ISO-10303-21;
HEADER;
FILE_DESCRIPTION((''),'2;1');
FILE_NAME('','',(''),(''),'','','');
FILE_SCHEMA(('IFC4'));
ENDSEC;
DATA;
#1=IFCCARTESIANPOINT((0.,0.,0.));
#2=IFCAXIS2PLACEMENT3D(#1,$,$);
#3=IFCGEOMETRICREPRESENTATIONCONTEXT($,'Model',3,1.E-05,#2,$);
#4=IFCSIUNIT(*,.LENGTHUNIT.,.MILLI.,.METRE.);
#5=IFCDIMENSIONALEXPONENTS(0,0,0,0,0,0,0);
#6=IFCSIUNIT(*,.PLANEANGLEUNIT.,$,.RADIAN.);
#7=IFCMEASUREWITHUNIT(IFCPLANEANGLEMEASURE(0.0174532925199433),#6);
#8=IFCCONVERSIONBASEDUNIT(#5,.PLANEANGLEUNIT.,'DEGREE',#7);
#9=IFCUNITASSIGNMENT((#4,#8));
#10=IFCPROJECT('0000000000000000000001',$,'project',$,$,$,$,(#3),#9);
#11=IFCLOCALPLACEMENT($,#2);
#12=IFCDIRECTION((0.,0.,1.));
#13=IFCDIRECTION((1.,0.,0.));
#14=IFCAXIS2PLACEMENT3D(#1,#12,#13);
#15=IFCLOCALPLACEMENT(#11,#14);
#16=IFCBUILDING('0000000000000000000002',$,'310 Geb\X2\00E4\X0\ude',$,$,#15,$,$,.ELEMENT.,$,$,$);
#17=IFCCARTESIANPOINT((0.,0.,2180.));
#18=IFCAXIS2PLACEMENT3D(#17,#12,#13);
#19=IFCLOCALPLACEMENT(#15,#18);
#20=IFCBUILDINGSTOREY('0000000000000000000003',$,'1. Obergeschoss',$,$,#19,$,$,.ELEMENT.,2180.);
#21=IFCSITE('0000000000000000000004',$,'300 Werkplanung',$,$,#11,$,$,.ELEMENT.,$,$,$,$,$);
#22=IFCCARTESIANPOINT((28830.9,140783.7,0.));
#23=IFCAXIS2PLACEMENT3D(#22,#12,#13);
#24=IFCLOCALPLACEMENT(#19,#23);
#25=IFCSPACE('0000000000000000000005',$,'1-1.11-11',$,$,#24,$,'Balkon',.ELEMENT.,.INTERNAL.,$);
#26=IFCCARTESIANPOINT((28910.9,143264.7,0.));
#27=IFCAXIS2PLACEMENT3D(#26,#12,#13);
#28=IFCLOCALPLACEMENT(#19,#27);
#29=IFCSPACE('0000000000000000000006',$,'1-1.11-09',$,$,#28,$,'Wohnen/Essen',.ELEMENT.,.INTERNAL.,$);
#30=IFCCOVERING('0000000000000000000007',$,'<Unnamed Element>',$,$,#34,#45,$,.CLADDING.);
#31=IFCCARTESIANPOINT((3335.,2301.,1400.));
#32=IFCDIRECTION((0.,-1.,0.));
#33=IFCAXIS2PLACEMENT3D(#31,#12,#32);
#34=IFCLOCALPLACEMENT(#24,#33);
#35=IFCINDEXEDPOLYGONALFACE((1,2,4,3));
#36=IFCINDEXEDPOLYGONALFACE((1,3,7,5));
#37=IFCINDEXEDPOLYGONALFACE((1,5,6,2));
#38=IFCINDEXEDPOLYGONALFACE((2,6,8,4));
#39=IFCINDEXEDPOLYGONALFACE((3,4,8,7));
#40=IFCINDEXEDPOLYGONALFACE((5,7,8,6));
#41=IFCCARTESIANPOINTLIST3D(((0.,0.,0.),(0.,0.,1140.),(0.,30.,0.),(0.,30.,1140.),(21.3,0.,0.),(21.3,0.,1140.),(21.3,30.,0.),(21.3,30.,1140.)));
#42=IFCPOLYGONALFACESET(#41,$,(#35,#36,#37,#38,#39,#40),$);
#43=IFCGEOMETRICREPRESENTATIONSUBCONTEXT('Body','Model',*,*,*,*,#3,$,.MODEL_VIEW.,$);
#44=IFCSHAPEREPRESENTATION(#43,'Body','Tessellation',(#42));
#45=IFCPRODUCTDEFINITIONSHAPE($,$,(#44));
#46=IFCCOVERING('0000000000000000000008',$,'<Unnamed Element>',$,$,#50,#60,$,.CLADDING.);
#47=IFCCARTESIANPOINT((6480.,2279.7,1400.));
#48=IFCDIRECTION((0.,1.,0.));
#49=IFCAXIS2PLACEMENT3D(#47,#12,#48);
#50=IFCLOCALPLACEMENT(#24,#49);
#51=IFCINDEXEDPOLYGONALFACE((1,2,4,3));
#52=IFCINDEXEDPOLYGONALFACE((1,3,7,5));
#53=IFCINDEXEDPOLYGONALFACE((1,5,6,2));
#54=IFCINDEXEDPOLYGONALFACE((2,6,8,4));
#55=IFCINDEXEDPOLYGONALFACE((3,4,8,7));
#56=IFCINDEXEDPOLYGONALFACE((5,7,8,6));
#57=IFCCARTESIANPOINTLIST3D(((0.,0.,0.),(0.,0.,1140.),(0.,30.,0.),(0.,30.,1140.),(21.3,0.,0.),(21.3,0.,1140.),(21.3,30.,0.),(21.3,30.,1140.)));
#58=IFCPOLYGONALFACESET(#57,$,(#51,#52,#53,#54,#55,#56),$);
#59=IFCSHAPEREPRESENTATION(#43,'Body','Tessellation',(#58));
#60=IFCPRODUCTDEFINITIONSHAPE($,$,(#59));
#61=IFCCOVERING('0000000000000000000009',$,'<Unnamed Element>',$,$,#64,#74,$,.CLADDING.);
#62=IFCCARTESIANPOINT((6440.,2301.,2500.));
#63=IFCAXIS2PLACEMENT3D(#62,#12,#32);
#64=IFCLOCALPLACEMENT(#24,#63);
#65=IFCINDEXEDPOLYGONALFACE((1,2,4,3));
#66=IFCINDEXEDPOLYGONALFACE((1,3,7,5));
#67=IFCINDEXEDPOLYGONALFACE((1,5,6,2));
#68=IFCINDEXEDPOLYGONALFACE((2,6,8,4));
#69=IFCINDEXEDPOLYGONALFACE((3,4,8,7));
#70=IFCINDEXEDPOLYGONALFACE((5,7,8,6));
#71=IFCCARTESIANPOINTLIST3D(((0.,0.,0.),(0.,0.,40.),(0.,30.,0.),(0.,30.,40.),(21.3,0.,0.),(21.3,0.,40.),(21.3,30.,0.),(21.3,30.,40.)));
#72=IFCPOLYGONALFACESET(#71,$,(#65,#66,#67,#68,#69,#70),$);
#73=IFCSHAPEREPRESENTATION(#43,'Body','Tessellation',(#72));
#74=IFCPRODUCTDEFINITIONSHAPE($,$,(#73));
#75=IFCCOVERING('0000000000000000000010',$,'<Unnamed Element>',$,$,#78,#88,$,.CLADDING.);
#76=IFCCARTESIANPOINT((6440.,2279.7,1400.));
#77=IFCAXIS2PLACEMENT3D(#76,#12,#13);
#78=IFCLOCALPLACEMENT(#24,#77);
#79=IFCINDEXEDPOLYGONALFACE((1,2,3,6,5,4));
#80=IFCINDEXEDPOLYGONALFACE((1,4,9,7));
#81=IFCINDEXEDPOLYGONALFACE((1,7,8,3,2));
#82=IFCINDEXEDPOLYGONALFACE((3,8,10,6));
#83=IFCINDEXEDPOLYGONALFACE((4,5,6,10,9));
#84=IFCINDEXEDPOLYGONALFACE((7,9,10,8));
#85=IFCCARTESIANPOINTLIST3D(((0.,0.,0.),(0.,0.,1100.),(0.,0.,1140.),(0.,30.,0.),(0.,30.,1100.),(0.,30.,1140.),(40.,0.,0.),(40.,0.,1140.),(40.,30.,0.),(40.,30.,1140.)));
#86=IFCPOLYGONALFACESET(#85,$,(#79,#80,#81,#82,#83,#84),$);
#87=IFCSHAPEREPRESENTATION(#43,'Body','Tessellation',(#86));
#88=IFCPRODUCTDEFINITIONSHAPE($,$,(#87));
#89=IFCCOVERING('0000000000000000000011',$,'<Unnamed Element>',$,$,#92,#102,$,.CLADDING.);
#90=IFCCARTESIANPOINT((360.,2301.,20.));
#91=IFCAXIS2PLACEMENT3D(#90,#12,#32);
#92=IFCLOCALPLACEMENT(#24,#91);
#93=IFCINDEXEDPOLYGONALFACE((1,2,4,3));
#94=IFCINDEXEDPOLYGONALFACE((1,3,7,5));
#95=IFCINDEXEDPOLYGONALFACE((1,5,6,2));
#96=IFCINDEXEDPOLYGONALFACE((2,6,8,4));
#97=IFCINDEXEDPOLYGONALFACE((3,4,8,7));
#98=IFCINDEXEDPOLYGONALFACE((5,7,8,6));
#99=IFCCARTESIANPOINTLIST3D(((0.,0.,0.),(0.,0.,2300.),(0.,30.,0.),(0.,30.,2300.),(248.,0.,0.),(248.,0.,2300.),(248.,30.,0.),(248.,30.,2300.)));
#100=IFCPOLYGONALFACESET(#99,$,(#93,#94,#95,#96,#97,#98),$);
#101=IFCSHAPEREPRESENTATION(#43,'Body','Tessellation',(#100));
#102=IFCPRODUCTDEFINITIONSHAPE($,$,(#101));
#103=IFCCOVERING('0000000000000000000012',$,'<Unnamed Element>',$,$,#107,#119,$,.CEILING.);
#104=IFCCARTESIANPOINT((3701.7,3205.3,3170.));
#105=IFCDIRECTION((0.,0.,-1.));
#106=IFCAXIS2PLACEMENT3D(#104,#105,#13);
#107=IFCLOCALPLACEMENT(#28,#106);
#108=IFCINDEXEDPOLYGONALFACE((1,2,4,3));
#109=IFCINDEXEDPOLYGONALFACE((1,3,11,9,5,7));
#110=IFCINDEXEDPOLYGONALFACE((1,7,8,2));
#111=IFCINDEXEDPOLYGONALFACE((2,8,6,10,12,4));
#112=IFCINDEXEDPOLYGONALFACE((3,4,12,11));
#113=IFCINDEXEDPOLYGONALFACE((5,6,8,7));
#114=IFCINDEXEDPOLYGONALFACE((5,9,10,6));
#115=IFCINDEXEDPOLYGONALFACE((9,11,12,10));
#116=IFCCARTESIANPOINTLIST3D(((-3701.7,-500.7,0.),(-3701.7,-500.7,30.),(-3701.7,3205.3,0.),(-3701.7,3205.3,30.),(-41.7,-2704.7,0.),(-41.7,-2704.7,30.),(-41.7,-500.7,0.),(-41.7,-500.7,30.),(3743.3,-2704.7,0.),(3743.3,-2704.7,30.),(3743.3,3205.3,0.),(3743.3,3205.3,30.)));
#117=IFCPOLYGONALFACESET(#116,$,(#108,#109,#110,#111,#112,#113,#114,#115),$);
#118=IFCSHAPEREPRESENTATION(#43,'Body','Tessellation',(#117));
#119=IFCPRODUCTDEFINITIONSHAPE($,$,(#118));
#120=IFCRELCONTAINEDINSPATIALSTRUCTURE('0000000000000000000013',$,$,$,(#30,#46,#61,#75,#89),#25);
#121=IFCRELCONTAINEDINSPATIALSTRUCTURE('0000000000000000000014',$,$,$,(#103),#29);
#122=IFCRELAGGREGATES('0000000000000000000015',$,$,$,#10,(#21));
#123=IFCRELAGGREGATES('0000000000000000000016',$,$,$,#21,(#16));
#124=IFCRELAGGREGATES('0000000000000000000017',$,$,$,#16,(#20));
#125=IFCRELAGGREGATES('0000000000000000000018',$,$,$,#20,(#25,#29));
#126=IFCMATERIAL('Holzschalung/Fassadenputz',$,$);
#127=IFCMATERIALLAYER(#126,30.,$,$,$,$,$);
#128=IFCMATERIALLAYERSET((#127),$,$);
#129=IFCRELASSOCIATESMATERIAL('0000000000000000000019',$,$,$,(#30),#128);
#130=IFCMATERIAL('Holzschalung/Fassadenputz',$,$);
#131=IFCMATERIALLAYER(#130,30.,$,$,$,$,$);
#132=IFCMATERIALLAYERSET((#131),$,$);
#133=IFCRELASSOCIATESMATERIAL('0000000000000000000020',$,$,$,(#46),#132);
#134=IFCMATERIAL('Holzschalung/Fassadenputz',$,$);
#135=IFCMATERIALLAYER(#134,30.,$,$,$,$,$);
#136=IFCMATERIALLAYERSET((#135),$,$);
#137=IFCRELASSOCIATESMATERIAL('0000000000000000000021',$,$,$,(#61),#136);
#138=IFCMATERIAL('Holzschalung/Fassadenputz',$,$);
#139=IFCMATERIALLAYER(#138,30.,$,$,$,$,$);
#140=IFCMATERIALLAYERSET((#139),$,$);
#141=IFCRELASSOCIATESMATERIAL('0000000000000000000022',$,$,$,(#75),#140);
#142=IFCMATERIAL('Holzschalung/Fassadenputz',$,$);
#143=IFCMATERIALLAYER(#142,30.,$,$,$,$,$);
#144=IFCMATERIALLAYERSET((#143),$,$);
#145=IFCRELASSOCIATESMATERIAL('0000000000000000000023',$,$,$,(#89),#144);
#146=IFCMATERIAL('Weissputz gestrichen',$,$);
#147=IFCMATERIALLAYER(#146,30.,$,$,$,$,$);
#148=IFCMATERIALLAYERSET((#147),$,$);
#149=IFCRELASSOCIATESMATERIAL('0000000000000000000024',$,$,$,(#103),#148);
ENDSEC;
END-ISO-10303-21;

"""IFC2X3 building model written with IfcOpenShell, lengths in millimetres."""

from ifc_helpers import new_model, entity, si_unit, converted_unit, frame, frame_2d, origin, origin_with_axes, place, context, subcontext, project, spatial, polyline, rectangle, outline, extrude, material, layer, layer_set, layer_usage, element, save


model = new_model("IFC2X3")

# Units and contexts
model_context = context("Model", 3, precision=1e-05, world=origin())
body_context = subcontext(model_context, "Body", "Model", "MODEL_VIEW")
ifc_project = project(units=[si_unit("LENGTHUNIT", "METRE", prefix="MILLI"), converted_unit("PLANEANGLEUNIT", "DEGREE", entity("IfcPlaneAngleMeasure", 0.0174532925199433), si_unit("PLANEANGLEUNIT", "RADIAN"), dimensions=[0, 0, 0, 0, 0, 0, 0])], contexts=[model_context])

# Site, building, storey
site_placement = place(None, origin())
site = spatial("IfcSite", under=ifc_project, at=site_placement, Name="300 Werkplanung", CompositionType="ELEMENT")
building_placement = place(site_placement, origin_with_axes())
building = spatial("IfcBuilding", under=site, at=building_placement, Name="310 Gebäude", CompositionType="ELEMENT")
storey_placement = place(building_placement, frame((0.0, 0.0, 2180.0), z_axis=(0.0, 0.0, 1.0), x_axis=(1.0, 0.0, 0.0)))
storey = spatial("IfcBuildingStorey", under=building, at=storey_placement, Name="1. Obergeschoss", CompositionType="ELEMENT", Elevation=2180.0)

# Shared definitions
space_1_placement = place(storey_placement, frame((28830.9, 140783.7, 0.0), z_axis=(0.0, 0.0, 1.0), x_axis=(1.0, 0.0, 0.0)))
space_1 = spatial("IfcSpace", under=storey, at=space_1_placement, Name="1-1.11-11", LongName="Balkon", CompositionType="ELEMENT", InteriorOrExteriorSpace="INTERNAL")

# Coverings
ifc_material_1 = material(Name="Holzschalung/Fassadenputz")
ifc_layer_1 = layer(ifc_material_1, 30.0)
ifc_layer_set_1 = layer_set([ifc_layer_1])
ifc_layer_usage_1 = layer_usage(ifc_layer_set_1, "AXIS3", "POSITIVE", 0.0)
covering_1_placement = place(space_1_placement, frame((3335.0, 2301.0, 1400.0), z_axis=(0.0, 0.0, 1.0), x_axis=(0.0, -1.0, 0.0)))
element("IfcCovering", 1, at=covering_1_placement, inside=space_1, material=ifc_layer_usage_1, Name="<Unnamed Element>", PredefinedType="CLADDING", context=body_context, shape_type="SweptSolid", body=[
    extrude(rectangle(XDim=1140.0, YDim=21.3, at=frame_2d((-10.7, 570.0), x_axis=(0.0, 1.0))), frame((21.3, 0.0, 1140.0), z_axis=(0.0, 1.0, 0.0), x_axis=(1.0, 0.0, 0.0)), (0.0, 0.0, 1.0), 30.0),
])
ifc_material_2 = material(Name="Holzschalung/Fassadenputz")
ifc_layer_2 = layer(ifc_material_2, 30.0)
ifc_layer_set_2 = layer_set([ifc_layer_2])
ifc_layer_usage_2 = layer_usage(ifc_layer_set_2, "AXIS3", "POSITIVE", 0.0)
covering_2_placement = place(space_1_placement, frame((6480.0, 2279.7, 1400.0), z_axis=(0.0, 0.0, 1.0), x_axis=(0.0, 1.0, 0.0)))
element("IfcCovering", 2, at=covering_2_placement, inside=space_1, material=ifc_layer_usage_2, Name="<Unnamed Element>", PredefinedType="CLADDING", context=body_context, shape_type="SweptSolid", body=[
    extrude(rectangle(XDim=1140.0, YDim=21.3, at=frame_2d((-10.6, 570.0), x_axis=(0.0, 1.0))), frame((21.3, 0.0, 1140.0), z_axis=(0.0, 1.0, 0.0), x_axis=(1.0, 0.0, 0.0)), (0.0, 0.0, 1.0), 30.0),
])
ifc_material_3 = material(Name="Holzschalung/Fassadenputz")
ifc_layer_3 = layer(ifc_material_3, 30.0)
ifc_layer_set_3 = layer_set([ifc_layer_3])
ifc_layer_usage_3 = layer_usage(ifc_layer_set_3, "AXIS3", "POSITIVE", 0.0)
covering_3_placement = place(space_1_placement, frame((6440.0, 2301.0, 2500.0), z_axis=(0.0, 0.0, 1.0), x_axis=(0.0, -1.0, 0.0)))
element("IfcCovering", 3, at=covering_3_placement, inside=space_1, material=ifc_layer_usage_3, Name="<Unnamed Element>", PredefinedType="CLADDING", context=body_context, shape_type="SweptSolid", body=[
    extrude(rectangle(XDim=21.3, YDim=40.0, at=frame_2d((-10.6, -20.0), x_axis=(-1.0, 0.0))), frame((21.3, 0.0, 0.0), z_axis=(0.0, 1.0, 0.0), x_axis=(1.0, 0.0, 0.0)), (0.0, 0.0, 1.0), 30.0),
])
ifc_material_4 = material(Name="Holzschalung/Fassadenputz")
ifc_layer_4 = layer(ifc_material_4, 30.0)
ifc_layer_set_4 = layer_set([ifc_layer_4])
ifc_layer_usage_4 = layer_usage(ifc_layer_set_4, "AXIS3", "POSITIVE", 0.0)
covering_4_placement = place(space_1_placement, frame((6440.0, 2279.7, 1400.0), z_axis=(0.0, 0.0, 1.0), x_axis=(1.0, 0.0, 0.0)))
element("IfcCovering", 4, at=covering_4_placement, inside=space_1, material=ifc_layer_usage_4, Name="<Unnamed Element>", PredefinedType="CLADDING", context=body_context, shape_type="SweptSolid", body=[
    extrude(outline(polyline([(0.0, 0.0), (40.0, 0.0), (40.0, -1140.0), (0.0, -1140.0), (0.0, -1100.0), (0.0, 0.0)])), frame((0.0, 0.0, 0.0), z_axis=(0.0, 1.0, 0.0), x_axis=(1.0, 0.0, 0.0)), (0.0, 0.0, 1.0), 30.0),
])
ifc_material_5 = material(Name="Holzschalung/Fassadenputz")
ifc_layer_5 = layer(ifc_material_5, 30.0)
ifc_layer_set_5 = layer_set([ifc_layer_5])
ifc_layer_usage_5 = layer_usage(ifc_layer_set_5, "AXIS3", "POSITIVE", 0.0)
covering_5_placement = place(space_1_placement, frame((360.0, 2301.0, 20.0), z_axis=(0.0, 0.0, 1.0), x_axis=(0.0, -1.0, 0.0)))
element("IfcCovering", 5, at=covering_5_placement, inside=space_1, material=ifc_layer_usage_5, Name="<Unnamed Element>", PredefinedType="CLADDING", context=body_context, shape_type="SweptSolid", body=[
    extrude(rectangle(XDim=248.0, YDim=2300.0, at=frame_2d((-124.0, -1150.0), x_axis=(-1.0, 0.0))), frame((248.0, 0.0, 0.0), z_axis=(0.0, 1.0, 0.0), x_axis=(1.0, 0.0, 0.0)), (0.0, 0.0, 1.0), 30.0),
])

# Shared definitions
space_2_placement = place(storey_placement, frame((28910.9, 143264.7, 0.0), z_axis=(0.0, 0.0, 1.0), x_axis=(1.0, 0.0, 0.0)))
space_2 = spatial("IfcSpace", under=storey, at=space_2_placement, Name="1-1.11-09", LongName="Wohnen/Essen", CompositionType="ELEMENT", InteriorOrExteriorSpace="INTERNAL")

# Covering
ifc_material_6 = material(Name="Weissputz gestrichen")
ifc_layer_6 = layer(ifc_material_6, 30.0)
ifc_layer_set_6 = layer_set([ifc_layer_6])
ifc_layer_usage_6 = layer_usage(ifc_layer_set_6, "AXIS3", "POSITIVE", 0.0)
covering_6_placement = place(space_2_placement, frame((3701.7, 3205.3, 3170.0), z_axis=(0.0, 0.0, -1.0), x_axis=(1.0, 0.0, 0.0)))
element("IfcCovering", 6, at=covering_6_placement, inside=space_2, material=ifc_layer_usage_6, Name="<Unnamed Element>", PredefinedType="CEILING", context=body_context, shape_type="SweptSolid", body=[
    extrude(outline(polyline([(-3701.7, -500.7), (-41.7, -500.7), (-41.7, -2704.7), (3743.3, -2704.7), (3743.3, 3205.3), (-3701.7, 3205.3), (-3701.7, -500.7)])), origin_with_axes(), (0.0, 0.0, 1.0), 30.0),
])

save(model, "model.ifc")
